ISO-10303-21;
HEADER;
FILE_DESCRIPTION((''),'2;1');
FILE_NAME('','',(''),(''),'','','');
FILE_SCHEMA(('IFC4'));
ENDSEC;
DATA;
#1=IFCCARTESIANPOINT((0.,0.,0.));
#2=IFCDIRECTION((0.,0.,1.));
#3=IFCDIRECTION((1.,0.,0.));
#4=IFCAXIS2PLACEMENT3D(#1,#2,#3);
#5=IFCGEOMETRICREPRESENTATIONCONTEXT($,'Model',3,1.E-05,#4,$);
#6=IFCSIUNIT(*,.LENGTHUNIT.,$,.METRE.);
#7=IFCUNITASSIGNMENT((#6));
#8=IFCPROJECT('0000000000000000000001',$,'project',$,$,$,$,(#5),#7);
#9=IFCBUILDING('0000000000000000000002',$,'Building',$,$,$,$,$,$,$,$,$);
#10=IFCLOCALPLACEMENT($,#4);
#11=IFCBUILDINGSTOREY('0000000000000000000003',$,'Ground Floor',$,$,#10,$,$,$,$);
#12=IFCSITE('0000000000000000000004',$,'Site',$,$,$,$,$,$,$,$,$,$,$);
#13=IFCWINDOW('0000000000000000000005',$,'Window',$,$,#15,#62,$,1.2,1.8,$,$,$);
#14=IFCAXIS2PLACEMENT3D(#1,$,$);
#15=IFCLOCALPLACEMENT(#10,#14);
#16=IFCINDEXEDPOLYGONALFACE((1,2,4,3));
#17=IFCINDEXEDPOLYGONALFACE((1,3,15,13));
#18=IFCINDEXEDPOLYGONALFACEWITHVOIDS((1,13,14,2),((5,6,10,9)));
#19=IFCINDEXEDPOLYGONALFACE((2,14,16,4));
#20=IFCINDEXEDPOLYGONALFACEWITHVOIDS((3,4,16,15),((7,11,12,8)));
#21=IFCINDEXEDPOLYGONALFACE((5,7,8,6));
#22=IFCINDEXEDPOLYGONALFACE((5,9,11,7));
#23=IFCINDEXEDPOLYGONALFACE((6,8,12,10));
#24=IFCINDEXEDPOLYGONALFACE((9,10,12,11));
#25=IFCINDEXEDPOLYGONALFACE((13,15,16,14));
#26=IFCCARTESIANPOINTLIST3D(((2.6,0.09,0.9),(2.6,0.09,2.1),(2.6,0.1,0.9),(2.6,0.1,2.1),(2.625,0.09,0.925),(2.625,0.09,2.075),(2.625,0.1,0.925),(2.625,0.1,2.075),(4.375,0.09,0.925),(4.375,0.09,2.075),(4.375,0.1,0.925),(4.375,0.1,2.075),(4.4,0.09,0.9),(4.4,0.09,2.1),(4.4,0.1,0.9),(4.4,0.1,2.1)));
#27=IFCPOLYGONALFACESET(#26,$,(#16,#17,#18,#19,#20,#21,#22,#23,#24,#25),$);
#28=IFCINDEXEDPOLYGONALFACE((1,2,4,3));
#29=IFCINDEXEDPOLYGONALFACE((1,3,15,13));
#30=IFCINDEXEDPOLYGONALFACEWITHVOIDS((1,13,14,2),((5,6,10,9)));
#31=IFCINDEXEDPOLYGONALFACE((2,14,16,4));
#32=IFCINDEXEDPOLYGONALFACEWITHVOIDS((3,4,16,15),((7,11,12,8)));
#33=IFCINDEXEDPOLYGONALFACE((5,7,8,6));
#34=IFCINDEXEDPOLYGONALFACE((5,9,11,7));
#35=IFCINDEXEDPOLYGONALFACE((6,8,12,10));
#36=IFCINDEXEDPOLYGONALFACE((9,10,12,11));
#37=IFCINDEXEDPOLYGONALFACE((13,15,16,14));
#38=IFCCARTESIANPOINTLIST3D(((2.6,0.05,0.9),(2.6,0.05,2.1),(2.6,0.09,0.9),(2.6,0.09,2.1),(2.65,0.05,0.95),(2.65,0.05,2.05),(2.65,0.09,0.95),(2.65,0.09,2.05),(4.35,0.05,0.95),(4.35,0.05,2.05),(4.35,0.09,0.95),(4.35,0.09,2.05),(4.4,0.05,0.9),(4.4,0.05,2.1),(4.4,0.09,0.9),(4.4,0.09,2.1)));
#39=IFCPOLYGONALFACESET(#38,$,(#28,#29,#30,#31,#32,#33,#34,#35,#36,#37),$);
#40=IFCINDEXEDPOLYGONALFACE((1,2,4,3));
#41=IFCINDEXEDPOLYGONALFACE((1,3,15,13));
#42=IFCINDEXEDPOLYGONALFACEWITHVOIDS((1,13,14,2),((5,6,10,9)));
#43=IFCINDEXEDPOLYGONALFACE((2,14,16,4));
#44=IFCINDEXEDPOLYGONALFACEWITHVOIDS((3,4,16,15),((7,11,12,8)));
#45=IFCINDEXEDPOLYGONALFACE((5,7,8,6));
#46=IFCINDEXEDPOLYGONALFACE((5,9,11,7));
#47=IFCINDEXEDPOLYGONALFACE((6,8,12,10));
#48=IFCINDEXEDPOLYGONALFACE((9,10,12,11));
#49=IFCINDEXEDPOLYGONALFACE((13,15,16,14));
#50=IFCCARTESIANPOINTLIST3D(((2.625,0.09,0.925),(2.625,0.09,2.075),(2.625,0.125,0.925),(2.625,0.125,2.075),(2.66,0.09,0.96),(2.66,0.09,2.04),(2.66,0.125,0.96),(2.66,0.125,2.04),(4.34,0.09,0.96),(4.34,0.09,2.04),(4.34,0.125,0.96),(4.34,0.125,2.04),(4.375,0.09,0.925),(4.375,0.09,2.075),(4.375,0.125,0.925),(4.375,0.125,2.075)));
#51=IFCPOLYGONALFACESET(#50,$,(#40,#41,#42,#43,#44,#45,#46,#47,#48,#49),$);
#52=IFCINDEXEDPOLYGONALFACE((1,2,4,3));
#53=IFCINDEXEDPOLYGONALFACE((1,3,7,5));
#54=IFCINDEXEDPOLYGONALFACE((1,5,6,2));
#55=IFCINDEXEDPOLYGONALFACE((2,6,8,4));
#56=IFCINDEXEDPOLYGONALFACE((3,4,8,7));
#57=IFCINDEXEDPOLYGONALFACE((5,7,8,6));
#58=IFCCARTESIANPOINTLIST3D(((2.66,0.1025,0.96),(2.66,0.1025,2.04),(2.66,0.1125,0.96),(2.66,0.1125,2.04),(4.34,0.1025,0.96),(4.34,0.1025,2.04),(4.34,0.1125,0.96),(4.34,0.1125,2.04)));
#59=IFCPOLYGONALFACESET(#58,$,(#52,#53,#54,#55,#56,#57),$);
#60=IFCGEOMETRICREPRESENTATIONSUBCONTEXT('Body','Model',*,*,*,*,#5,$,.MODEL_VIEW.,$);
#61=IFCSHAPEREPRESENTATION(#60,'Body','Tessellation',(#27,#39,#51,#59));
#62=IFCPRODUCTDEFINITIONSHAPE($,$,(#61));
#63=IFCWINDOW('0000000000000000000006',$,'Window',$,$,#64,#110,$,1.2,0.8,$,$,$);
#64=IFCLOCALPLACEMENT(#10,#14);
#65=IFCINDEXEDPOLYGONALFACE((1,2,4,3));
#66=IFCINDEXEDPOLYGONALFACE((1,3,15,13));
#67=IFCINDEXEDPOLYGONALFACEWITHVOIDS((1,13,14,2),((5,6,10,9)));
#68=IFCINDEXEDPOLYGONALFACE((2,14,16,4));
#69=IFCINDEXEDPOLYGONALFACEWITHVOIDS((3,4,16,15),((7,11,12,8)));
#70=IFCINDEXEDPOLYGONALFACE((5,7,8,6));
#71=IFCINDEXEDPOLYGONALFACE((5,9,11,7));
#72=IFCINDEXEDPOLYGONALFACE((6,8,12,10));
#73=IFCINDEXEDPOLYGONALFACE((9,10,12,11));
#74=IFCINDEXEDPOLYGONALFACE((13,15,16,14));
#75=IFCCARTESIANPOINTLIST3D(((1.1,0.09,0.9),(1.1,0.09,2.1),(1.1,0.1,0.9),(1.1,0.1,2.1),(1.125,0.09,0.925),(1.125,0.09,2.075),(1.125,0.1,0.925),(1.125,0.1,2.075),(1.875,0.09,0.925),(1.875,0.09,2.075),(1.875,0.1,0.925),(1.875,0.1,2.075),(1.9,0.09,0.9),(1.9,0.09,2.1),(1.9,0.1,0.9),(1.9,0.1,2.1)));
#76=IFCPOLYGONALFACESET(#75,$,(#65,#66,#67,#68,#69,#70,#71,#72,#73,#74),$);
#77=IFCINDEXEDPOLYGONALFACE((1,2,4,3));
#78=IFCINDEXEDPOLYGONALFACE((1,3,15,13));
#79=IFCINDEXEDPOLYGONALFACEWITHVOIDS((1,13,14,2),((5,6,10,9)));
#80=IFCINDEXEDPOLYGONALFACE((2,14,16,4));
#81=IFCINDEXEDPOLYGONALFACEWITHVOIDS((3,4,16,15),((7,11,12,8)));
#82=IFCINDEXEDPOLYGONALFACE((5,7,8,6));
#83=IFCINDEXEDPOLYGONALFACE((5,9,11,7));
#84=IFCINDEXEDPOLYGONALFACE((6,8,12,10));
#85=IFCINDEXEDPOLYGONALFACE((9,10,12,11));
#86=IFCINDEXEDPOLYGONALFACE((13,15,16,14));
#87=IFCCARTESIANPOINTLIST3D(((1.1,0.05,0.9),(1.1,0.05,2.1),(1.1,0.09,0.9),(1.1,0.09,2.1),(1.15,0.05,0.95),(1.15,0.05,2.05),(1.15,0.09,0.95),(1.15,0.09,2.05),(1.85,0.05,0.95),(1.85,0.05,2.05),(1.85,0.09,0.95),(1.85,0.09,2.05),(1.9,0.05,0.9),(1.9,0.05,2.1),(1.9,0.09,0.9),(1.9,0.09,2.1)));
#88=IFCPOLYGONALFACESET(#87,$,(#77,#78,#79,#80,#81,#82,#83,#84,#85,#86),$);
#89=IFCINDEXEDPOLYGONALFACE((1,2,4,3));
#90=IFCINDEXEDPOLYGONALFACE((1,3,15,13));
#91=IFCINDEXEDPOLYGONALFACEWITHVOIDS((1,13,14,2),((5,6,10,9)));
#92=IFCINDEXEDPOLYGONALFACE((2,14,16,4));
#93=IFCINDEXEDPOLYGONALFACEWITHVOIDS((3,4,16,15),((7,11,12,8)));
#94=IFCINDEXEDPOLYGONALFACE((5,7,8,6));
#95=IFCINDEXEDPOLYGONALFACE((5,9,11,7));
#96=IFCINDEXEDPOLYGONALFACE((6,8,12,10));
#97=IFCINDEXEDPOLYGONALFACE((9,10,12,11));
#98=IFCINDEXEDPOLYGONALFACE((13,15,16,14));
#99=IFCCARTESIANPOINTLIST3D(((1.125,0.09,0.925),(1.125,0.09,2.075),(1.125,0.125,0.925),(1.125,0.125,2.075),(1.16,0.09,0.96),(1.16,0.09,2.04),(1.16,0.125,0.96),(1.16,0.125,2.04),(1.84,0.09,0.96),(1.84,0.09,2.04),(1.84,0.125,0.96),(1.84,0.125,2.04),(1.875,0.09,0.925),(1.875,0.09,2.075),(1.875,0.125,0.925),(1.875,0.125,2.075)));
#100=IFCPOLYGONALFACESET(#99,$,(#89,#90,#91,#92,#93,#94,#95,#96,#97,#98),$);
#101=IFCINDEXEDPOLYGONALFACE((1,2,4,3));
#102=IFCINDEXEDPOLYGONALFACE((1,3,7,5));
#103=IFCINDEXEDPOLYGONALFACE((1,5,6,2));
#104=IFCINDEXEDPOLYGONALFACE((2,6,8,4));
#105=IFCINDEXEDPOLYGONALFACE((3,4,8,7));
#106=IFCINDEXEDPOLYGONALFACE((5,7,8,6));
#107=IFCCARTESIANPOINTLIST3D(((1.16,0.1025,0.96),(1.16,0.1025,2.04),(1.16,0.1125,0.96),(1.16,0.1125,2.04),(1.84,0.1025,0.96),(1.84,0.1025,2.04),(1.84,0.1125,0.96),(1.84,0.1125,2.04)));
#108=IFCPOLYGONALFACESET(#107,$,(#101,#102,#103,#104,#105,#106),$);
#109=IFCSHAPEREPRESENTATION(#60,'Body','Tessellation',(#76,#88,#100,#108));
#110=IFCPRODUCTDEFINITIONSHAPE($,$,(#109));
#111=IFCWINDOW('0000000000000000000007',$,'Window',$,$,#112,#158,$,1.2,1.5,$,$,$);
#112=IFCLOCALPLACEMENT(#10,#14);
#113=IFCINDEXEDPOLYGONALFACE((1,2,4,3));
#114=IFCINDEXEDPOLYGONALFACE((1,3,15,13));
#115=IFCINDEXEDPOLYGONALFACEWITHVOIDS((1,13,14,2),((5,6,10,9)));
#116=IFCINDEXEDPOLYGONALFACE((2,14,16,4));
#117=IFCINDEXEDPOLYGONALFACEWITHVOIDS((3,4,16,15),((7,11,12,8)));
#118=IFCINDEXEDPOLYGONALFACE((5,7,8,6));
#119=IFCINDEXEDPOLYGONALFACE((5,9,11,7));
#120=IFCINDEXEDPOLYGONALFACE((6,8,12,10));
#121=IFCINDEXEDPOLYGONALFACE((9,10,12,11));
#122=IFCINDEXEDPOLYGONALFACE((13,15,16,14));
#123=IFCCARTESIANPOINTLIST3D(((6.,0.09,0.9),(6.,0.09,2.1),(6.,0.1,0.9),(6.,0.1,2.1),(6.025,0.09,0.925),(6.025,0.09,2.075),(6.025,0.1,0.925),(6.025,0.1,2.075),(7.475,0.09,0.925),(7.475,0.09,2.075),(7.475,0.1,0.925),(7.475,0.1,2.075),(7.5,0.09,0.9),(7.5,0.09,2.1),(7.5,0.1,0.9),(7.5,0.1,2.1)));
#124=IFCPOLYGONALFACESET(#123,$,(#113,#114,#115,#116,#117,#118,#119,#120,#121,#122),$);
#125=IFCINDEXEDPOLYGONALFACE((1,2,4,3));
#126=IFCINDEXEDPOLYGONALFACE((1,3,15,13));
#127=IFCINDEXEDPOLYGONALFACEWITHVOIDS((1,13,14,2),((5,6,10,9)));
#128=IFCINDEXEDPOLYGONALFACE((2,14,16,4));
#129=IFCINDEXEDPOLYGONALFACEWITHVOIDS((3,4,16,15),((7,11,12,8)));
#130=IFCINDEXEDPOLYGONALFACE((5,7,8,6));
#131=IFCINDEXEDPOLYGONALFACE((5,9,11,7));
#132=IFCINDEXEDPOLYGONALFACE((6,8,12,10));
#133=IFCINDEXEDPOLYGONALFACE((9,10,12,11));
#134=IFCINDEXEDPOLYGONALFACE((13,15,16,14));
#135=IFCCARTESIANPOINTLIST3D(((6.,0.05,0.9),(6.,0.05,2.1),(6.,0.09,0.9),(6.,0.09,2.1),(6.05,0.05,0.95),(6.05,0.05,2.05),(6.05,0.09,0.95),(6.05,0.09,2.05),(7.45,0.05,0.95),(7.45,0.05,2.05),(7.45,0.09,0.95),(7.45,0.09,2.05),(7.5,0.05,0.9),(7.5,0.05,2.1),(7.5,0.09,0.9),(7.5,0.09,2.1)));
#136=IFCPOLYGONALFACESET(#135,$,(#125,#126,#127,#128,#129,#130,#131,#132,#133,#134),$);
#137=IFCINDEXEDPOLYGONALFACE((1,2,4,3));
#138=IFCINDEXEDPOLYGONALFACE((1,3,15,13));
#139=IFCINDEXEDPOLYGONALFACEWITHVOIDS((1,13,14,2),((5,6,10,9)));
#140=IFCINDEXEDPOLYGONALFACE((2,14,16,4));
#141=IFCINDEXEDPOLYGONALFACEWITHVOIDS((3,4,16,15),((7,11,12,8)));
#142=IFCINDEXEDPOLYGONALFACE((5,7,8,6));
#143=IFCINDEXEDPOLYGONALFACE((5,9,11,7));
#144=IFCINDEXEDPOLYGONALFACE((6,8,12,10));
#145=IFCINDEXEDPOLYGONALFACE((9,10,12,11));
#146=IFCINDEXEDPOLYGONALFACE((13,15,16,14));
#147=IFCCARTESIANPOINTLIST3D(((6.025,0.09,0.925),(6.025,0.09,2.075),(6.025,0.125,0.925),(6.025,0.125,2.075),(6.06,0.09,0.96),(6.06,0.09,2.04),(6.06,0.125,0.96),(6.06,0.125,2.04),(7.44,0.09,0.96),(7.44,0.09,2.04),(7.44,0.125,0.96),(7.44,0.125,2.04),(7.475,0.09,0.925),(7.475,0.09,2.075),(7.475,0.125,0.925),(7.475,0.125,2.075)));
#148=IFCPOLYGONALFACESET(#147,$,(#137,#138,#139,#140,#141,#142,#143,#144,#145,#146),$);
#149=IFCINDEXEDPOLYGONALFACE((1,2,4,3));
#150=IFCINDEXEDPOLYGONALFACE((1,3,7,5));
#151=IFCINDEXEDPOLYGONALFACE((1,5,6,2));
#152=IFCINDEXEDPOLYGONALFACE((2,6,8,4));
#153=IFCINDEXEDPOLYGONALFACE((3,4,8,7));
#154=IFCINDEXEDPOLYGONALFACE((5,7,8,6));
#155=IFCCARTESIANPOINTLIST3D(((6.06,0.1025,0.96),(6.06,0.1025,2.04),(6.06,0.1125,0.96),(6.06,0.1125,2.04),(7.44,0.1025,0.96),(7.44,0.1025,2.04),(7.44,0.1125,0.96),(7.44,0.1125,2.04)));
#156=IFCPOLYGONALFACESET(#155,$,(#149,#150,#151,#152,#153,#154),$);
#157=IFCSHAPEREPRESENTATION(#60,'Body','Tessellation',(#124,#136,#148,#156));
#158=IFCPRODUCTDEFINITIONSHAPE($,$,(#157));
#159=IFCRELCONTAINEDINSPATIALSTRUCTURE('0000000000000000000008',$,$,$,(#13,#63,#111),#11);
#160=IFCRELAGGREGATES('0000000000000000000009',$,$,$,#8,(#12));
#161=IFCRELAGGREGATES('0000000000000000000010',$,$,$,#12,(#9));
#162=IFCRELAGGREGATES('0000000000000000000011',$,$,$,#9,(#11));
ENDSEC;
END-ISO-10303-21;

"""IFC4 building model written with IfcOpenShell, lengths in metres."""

from ifc_helpers import new_model, si_unit, frame, origin_with_axes, place, context, subcontext, project, spatial, line, indexed_curve, outline, extrude, element, save


model = new_model("IFC4")

# Units and contexts
model_context = context("Model", 3, precision=1e-05, world=origin_with_axes())
body_context = subcontext(model_context, "Body", "Model", "MODEL_VIEW")
ifc_project = project(units=[si_unit("LENGTHUNIT", "METRE")], contexts=[model_context])

# Site, building, storey
site = spatial("IfcSite", under=ifc_project, Name="Site")
building = spatial("IfcBuilding", under=site, Name="Building")
storey_placement = place(None, origin_with_axes())
storey = spatial("IfcBuildingStorey", under=building, at=storey_placement, Name="Ground Floor")

# Windows
window_1_placement = place(storey_placement, frame((2.6, 0.0, 0.9), z_axis=(0.0, 0.0, 1.0), x_axis=(1.0, 0.0, 0.0)))
element("IfcWindow", 1, at=window_1_placement, inside=storey, Name="Window", OverallHeight=1.2, OverallWidth=1.8, context=body_context, shape_type="SweptSolid", body=[
    extrude(outline(indexed_curve([(0.0, 0.0), (1.8, 0.0), (1.8, 1.2), (0.0, 1.2)], segments=[line(1, 2, 3, 4, 1)]), holes=[indexed_curve([(0.025, 0.025), (1.775, 0.025), (1.775, 1.175), (0.025, 1.175)], segments=[line(1, 2, 3, 4, 1)])]), frame((0.0, 0.09, 0.0), z_axis=(0.0, -1.0, 0.0), x_axis=(1.0, 0.0, 0.0)), (0.0, 0.0, -1.0), 0.01),
    extrude(outline(indexed_curve([(0.0, 0.0), (1.8, 0.0), (1.8, 1.2), (0.0, 1.2)], segments=[line(1, 2, 3, 4, 1)]), holes=[indexed_curve([(0.05, 0.05), (1.75, 0.05), (1.75, 1.15), (0.05, 1.15)], segments=[line(1, 2, 3, 4, 1)])]), frame((0.0, 0.05, 0.0), z_axis=(0.0, -1.0, 0.0), x_axis=(1.0, 0.0, 0.0)), (0.0, 0.0, -1.0), 0.04),
    extrude(outline(indexed_curve([(0.0, 0.0), (1.75, 0.0), (1.75, 1.15), (0.0, 1.15)], segments=[line(1, 2, 3, 4, 1)]), holes=[indexed_curve([(0.035, 0.035), (1.715, 0.035), (1.715, 1.115), (0.035, 1.115)], segments=[line(1, 2, 3, 4, 1)])]), frame((0.025, 0.09, 0.025), z_axis=(0.0, -1.0, 0.0), x_axis=(1.0, 0.0, 0.0)), (0.0, 0.0, -1.0), 0.035),
    extrude(outline(indexed_curve([(0.035, 0.035), (1.715, 0.035), (1.715, 1.115), (0.035, 1.115)], segments=[line(1, 2, 3, 4, 1)])), frame((0.025, 0.1025, 0.025), z_axis=(0.0, -1.0, 0.0), x_axis=(1.0, 0.0, 0.0)), (0.0, 0.0, -1.0), 0.01),
])
window_2_placement = place(storey_placement, frame((1.1, 0.0, 0.9), z_axis=(0.0, 0.0, 1.0), x_axis=(1.0, 0.0, 0.0)))
element("IfcWindow", 2, at=window_2_placement, inside=storey, Name="Window", OverallHeight=1.2, OverallWidth=0.8, context=body_context, shape_type="SweptSolid", body=[
    extrude(outline(indexed_curve([(0.0, 0.0), (0.8, 0.0), (0.8, 1.2), (0.0, 1.2)], segments=[line(1, 2, 3, 4, 1)]), holes=[indexed_curve([(0.025, 0.025), (0.775, 0.025), (0.775, 1.175), (0.025, 1.175)], segments=[line(1, 2, 3, 4, 1)])]), frame((0.0, 0.09, 0.0), z_axis=(0.0, -1.0, 0.0), x_axis=(1.0, 0.0, 0.0)), (0.0, 0.0, -1.0), 0.01),
    extrude(outline(indexed_curve([(0.0, 0.0), (0.8, 0.0), (0.8, 1.2), (0.0, 1.2)], segments=[line(1, 2, 3, 4, 1)]), holes=[indexed_curve([(0.05, 0.05), (0.75, 0.05), (0.75, 1.15), (0.05, 1.15)], segments=[line(1, 2, 3, 4, 1)])]), frame((0.0, 0.05, 0.0), z_axis=(0.0, -1.0, 0.0), x_axis=(1.0, 0.0, 0.0)), (0.0, 0.0, -1.0), 0.04),
    extrude(outline(indexed_curve([(0.0, 0.0), (0.75, 0.0), (0.75, 1.15), (0.0, 1.15)], segments=[line(1, 2, 3, 4, 1)]), holes=[indexed_curve([(0.035, 0.035), (0.715, 0.035), (0.715, 1.115), (0.035, 1.115)], segments=[line(1, 2, 3, 4, 1)])]), frame((0.025, 0.09, 0.025), z_axis=(0.0, -1.0, 0.0), x_axis=(1.0, 0.0, 0.0)), (0.0, 0.0, -1.0), 0.035),
    extrude(outline(indexed_curve([(0.035, 0.035), (0.715, 0.035), (0.715, 1.115), (0.035, 1.115)], segments=[line(1, 2, 3, 4, 1)])), frame((0.025, 0.1025, 0.025), z_axis=(0.0, -1.0, 0.0), x_axis=(1.0, 0.0, 0.0)), (0.0, 0.0, -1.0), 0.01),
])
window_3_placement = place(storey_placement, frame((6.0, 0.0, 0.9), z_axis=(0.0, 0.0, 1.0), x_axis=(1.0, 0.0, 0.0)))
element("IfcWindow", 3, at=window_3_placement, inside=storey, Name="Window", OverallHeight=1.2, OverallWidth=1.5, context=body_context, shape_type="SweptSolid", body=[
    extrude(outline(indexed_curve([(0.0, 0.0), (1.5, 0.0), (1.5, 1.2), (0.0, 1.2)], segments=[line(1, 2, 3, 4, 1)]), holes=[indexed_curve([(0.025, 0.025), (1.475, 0.025), (1.475, 1.175), (0.025, 1.175)], segments=[line(1, 2, 3, 4, 1)])]), frame((0.0, 0.09, 0.0), z_axis=(0.0, -1.0, 0.0), x_axis=(1.0, 0.0, 0.0)), (0.0, 0.0, -1.0), 0.01),
    extrude(outline(indexed_curve([(0.0, 0.0), (1.5, 0.0), (1.5, 1.2), (0.0, 1.2)], segments=[line(1, 2, 3, 4, 1)]), holes=[indexed_curve([(0.05, 0.05), (1.45, 0.05), (1.45, 1.15), (0.05, 1.15)], segments=[line(1, 2, 3, 4, 1)])]), frame((0.0, 0.05, 0.0), z_axis=(0.0, -1.0, 0.0), x_axis=(1.0, 0.0, 0.0)), (0.0, 0.0, -1.0), 0.04),
    extrude(outline(indexed_curve([(0.0, 0.0), (1.45, 0.0), (1.45, 1.15), (0.0, 1.15)], segments=[line(1, 2, 3, 4, 1)]), holes=[indexed_curve([(0.035, 0.035), (1.415, 0.035), (1.415, 1.115), (0.035, 1.115)], segments=[line(1, 2, 3, 4, 1)])]), frame((0.025, 0.09, 0.025), z_axis=(0.0, -1.0, 0.0), x_axis=(1.0, 0.0, 0.0)), (0.0, 0.0, -1.0), 0.035),
    extrude(outline(indexed_curve([(0.035, 0.035), (1.415, 0.035), (1.415, 1.115), (0.035, 1.115)], segments=[line(1, 2, 3, 4, 1)])), frame((0.025, 0.1025, 0.025), z_axis=(0.0, -1.0, 0.0), x_axis=(1.0, 0.0, 0.0)), (0.0, 0.0, -1.0), 0.01),
])

save(model, "model.ifc")
